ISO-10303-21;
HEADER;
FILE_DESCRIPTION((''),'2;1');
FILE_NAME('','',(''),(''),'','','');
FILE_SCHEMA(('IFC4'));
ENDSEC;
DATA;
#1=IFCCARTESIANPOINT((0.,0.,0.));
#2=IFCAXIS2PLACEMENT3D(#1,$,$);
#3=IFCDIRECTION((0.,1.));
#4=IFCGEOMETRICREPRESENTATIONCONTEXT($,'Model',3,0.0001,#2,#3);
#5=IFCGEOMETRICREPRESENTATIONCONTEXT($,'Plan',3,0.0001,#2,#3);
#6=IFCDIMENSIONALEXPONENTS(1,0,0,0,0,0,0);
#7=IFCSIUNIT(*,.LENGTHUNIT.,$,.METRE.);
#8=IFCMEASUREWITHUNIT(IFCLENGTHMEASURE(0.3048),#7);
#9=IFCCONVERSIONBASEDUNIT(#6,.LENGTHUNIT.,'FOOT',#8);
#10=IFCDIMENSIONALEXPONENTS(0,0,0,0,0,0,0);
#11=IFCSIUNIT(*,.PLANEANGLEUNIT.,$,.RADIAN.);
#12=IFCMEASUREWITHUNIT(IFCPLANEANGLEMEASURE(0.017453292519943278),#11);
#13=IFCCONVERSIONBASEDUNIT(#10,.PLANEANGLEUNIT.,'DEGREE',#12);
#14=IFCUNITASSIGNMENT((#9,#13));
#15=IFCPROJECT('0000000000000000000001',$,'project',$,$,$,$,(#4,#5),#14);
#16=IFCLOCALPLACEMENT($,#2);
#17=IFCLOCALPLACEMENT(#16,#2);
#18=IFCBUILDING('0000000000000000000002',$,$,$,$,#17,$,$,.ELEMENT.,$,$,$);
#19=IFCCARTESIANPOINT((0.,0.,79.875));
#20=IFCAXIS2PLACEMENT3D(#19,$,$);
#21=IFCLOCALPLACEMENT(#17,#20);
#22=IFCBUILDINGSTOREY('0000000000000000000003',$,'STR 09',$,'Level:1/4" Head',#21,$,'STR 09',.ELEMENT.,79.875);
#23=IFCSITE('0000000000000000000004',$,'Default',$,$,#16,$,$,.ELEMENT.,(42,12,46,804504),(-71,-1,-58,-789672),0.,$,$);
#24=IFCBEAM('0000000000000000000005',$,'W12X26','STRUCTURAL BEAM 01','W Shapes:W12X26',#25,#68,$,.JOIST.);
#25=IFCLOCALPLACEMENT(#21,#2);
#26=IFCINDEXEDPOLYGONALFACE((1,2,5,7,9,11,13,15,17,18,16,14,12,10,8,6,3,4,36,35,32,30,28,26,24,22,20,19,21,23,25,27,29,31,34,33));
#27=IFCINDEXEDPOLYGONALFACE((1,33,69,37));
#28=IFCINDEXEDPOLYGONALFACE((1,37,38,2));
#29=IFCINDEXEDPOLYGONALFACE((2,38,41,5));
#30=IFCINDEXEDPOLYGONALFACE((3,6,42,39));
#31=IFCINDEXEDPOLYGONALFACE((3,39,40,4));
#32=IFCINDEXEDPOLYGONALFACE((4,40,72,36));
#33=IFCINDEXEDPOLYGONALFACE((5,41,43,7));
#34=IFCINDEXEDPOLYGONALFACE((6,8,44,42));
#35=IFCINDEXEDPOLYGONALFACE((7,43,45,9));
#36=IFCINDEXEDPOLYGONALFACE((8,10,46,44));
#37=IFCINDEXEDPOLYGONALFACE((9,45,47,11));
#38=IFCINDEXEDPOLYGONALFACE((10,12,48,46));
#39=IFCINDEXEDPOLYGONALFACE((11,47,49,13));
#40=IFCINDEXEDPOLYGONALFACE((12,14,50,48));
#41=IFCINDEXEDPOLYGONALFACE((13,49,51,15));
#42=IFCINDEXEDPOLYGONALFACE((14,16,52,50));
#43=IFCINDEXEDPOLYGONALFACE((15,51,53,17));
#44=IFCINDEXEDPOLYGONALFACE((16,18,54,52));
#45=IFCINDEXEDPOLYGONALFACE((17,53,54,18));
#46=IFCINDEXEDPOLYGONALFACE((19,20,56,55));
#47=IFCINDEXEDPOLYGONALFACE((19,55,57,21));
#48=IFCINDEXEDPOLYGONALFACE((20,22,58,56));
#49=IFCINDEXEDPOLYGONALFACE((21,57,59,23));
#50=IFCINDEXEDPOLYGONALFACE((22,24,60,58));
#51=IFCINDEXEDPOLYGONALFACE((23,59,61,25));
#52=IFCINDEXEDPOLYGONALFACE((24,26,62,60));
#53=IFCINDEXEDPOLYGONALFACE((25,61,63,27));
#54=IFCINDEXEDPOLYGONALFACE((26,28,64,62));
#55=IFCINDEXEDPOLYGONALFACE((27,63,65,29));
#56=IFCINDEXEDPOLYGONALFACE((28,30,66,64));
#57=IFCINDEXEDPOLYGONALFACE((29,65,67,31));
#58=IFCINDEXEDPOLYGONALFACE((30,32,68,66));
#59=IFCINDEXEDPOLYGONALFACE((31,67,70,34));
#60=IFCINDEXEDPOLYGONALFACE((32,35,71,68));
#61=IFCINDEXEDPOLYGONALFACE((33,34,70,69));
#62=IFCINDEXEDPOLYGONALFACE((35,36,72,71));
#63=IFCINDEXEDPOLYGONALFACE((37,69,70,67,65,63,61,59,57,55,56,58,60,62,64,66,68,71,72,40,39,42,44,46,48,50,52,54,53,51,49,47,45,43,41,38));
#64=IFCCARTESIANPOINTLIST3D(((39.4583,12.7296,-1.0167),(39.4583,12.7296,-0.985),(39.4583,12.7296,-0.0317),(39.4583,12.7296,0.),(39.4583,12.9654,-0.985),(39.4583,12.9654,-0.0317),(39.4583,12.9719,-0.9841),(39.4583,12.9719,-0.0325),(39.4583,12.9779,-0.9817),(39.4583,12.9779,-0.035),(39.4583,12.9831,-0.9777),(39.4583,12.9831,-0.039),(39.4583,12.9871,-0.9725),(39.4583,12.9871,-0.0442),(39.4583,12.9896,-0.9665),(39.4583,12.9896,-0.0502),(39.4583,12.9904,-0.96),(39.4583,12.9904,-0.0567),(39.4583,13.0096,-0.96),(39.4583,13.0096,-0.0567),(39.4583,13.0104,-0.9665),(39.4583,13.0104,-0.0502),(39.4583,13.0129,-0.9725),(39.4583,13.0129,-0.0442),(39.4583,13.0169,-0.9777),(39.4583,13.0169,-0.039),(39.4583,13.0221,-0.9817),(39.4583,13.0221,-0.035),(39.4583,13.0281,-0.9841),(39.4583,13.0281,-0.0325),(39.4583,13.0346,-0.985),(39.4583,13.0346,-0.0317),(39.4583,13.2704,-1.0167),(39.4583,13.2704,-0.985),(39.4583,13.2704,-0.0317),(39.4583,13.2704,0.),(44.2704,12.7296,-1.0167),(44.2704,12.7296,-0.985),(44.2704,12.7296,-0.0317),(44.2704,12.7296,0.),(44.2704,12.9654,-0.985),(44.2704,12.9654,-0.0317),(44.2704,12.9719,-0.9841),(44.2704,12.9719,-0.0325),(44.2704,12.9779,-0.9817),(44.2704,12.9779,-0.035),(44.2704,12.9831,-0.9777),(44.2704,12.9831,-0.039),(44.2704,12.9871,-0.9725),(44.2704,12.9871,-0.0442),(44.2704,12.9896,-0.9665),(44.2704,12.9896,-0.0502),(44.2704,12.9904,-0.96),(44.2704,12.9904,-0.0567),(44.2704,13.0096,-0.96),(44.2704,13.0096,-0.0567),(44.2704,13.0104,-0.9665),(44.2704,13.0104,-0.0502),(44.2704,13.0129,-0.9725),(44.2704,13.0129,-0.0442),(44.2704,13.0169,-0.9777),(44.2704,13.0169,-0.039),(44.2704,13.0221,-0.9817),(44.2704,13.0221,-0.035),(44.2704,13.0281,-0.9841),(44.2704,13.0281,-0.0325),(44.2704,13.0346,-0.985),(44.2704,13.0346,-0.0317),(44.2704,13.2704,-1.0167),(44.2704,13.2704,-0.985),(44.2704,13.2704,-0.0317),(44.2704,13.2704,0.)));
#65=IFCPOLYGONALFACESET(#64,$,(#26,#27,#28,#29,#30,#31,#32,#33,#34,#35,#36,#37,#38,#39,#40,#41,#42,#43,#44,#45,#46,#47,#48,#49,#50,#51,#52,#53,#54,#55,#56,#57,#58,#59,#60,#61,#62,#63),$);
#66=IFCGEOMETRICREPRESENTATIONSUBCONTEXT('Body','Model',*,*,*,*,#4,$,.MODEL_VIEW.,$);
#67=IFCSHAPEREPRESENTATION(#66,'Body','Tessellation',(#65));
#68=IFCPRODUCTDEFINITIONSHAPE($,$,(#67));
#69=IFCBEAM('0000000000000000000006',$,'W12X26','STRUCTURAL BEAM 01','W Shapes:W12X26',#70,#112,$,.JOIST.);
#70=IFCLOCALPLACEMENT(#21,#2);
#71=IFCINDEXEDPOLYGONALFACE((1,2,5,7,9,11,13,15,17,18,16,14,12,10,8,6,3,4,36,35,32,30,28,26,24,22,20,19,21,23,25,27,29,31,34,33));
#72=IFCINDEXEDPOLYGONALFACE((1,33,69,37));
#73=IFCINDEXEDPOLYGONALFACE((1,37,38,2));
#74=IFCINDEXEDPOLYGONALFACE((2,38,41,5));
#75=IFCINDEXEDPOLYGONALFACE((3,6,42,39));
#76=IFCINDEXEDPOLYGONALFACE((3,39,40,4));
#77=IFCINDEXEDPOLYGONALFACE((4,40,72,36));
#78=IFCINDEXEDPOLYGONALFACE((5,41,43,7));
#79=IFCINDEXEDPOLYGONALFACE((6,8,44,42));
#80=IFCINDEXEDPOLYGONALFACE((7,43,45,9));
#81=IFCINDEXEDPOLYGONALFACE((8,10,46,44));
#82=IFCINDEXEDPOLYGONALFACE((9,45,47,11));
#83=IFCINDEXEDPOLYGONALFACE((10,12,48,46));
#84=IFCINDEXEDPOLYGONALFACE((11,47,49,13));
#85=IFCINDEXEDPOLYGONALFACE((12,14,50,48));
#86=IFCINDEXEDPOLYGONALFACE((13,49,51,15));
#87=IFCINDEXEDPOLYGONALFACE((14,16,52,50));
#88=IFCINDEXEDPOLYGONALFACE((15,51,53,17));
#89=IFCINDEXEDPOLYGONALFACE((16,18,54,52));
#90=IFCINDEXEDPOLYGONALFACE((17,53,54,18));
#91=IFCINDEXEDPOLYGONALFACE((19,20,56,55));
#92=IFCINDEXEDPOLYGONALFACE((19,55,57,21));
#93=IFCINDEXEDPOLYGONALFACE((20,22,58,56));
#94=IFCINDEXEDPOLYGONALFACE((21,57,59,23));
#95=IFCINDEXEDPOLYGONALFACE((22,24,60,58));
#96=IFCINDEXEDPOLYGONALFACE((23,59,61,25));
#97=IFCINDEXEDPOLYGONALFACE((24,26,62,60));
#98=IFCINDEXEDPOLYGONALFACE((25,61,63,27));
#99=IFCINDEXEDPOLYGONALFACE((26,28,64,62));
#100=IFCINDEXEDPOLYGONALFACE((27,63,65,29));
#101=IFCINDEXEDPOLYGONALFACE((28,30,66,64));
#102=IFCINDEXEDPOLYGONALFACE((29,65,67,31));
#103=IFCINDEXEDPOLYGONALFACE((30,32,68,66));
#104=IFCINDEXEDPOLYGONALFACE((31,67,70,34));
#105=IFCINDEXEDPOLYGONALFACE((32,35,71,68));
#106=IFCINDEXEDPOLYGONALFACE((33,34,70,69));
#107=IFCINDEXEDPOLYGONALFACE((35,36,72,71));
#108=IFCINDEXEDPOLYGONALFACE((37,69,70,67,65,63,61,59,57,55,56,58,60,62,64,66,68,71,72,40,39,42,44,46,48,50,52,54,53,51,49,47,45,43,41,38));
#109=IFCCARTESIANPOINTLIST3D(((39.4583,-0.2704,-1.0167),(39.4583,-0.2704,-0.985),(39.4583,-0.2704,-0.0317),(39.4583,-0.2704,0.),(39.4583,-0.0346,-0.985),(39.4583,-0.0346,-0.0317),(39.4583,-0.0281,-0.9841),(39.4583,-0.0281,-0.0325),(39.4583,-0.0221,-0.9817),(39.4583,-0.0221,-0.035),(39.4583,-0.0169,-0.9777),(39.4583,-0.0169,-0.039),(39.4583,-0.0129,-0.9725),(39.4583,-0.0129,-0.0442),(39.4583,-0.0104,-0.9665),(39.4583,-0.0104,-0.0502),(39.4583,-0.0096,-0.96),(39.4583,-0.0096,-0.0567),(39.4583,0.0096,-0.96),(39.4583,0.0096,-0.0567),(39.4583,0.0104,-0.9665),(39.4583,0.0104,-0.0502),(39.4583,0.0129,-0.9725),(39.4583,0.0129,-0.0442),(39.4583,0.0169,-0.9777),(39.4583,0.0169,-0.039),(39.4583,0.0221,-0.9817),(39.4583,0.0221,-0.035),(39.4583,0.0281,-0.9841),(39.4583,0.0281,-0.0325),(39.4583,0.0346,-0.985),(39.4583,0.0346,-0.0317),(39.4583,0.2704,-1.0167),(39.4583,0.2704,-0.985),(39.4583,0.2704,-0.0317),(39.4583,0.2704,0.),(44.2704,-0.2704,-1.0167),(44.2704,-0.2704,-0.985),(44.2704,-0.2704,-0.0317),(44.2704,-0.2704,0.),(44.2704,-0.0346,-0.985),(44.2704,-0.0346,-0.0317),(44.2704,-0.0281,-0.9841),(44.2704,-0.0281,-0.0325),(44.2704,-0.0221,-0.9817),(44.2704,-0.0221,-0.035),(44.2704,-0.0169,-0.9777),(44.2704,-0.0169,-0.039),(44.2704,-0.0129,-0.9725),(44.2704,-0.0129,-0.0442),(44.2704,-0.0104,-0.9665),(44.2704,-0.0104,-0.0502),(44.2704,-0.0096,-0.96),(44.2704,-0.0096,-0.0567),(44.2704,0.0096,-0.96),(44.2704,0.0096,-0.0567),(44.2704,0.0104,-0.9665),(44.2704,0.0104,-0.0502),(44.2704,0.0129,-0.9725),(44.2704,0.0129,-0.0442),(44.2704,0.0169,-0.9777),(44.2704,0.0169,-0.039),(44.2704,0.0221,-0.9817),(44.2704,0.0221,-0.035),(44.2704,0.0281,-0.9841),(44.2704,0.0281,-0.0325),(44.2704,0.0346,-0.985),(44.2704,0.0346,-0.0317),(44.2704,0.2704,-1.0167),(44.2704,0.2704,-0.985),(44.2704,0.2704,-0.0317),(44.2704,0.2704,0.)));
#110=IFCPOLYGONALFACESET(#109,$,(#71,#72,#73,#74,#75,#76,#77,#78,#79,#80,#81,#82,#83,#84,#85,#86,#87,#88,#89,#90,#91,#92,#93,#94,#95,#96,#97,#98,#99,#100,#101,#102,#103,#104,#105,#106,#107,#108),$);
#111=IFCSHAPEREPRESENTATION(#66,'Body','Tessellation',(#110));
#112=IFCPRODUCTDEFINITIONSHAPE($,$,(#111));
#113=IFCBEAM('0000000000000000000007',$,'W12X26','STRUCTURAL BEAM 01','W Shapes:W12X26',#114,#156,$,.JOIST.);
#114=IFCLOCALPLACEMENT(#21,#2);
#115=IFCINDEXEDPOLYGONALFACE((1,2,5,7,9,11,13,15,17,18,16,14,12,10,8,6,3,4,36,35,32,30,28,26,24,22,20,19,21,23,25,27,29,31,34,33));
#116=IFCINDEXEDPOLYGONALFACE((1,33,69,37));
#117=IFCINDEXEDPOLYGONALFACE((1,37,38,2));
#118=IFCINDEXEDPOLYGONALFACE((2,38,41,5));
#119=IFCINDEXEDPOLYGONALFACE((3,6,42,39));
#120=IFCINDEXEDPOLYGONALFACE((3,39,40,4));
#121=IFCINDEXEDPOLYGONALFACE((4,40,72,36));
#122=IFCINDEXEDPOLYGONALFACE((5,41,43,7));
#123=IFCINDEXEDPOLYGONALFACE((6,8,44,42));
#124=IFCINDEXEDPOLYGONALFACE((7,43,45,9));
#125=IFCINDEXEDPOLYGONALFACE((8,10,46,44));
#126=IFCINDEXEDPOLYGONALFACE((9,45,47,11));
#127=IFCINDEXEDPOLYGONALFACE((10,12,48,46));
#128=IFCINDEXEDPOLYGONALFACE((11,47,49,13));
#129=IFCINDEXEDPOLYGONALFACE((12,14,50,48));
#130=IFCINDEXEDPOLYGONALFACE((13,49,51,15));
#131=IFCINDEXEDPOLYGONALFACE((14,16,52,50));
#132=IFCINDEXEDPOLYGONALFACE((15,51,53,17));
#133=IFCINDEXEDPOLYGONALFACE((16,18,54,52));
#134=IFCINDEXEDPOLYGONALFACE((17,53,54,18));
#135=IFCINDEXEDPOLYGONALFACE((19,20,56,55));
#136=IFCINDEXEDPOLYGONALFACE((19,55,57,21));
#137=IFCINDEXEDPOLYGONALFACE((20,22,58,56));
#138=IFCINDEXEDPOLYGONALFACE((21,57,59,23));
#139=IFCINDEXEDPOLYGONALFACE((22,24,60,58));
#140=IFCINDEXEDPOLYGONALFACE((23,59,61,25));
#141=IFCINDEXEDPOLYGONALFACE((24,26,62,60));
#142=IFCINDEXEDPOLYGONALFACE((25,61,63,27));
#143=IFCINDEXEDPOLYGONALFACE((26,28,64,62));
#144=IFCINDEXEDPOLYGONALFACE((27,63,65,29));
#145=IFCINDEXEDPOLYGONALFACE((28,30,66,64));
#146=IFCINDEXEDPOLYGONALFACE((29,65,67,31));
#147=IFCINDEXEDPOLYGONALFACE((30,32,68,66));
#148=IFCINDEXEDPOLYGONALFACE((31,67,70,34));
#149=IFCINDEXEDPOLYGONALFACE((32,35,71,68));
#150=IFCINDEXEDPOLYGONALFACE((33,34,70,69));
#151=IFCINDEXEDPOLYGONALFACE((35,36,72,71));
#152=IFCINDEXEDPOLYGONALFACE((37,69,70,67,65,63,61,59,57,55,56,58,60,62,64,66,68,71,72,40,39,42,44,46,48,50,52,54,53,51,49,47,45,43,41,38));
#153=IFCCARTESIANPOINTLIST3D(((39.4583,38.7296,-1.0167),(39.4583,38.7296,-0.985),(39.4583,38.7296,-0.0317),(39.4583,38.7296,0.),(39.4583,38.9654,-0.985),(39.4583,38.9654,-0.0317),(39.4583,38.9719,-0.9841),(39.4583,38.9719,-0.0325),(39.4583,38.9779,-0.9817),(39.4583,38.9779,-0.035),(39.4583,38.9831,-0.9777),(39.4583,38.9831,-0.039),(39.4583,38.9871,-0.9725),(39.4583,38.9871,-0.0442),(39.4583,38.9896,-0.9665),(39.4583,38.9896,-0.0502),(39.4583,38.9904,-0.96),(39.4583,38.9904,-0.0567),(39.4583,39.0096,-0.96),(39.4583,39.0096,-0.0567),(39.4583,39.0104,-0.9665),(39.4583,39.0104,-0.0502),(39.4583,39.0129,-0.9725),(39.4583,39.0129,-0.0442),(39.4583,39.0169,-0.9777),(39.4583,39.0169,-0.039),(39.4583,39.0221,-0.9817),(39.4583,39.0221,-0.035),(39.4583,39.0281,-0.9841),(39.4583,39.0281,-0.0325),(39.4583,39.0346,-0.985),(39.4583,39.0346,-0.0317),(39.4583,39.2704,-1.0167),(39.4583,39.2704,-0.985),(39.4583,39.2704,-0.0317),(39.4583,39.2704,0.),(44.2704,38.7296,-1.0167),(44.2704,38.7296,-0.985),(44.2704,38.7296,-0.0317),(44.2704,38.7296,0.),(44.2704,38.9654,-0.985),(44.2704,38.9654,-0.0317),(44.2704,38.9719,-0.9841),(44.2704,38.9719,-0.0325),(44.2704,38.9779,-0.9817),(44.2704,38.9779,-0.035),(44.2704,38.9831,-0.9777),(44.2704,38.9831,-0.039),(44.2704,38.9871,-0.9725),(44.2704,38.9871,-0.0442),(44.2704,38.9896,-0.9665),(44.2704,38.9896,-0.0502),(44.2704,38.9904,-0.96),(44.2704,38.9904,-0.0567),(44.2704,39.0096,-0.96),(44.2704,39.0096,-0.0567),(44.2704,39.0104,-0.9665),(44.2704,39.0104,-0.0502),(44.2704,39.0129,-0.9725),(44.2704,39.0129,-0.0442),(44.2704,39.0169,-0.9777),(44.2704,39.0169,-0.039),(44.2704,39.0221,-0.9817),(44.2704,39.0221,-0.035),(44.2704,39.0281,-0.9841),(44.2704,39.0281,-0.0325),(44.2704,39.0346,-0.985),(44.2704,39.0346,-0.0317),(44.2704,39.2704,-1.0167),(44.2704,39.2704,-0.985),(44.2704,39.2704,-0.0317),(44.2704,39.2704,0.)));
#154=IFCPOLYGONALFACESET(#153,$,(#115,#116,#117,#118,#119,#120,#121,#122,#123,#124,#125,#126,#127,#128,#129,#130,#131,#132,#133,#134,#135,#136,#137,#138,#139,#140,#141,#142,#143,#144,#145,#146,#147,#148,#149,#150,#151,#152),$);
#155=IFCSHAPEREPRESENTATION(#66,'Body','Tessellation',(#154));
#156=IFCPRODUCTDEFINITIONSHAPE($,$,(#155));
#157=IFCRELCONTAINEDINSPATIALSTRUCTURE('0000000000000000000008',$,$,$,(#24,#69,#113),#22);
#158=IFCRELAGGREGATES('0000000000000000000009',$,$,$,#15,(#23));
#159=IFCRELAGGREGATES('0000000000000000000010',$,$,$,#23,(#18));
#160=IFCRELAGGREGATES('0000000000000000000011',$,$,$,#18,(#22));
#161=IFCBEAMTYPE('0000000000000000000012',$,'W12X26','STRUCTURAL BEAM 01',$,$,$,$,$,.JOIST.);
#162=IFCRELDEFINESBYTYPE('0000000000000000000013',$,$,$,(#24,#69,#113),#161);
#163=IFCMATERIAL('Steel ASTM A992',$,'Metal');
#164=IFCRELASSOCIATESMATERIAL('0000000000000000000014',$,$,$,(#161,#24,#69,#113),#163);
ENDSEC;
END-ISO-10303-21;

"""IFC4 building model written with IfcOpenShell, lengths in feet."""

from ifc_helpers import new_model, entity, si_unit, converted_unit, direction, frame, origin, place, context, subcontext, project, spatial, line, arc, indexed_curve, outline, extrude, source, transform, mapped, material, type_object, type_shapes, element, save


model = new_model("IFC4")

# Units and contexts
model_context = context("Model", 3, precision=0.0001, world=origin(), true_north=direction((0.0, 1.0)))
plan_context = context("Plan", 3, precision=0.0001, world=origin(), true_north=direction((0.0, 1.0)))
body_context = subcontext(model_context, "Body", "Model", "MODEL_VIEW")
ifc_project = project(units=[converted_unit("LENGTHUNIT", "FOOT", entity("IfcLengthMeasure", 0.3048), si_unit("LENGTHUNIT", "METRE"), dimensions=[1, 0, 0, 0, 0, 0, 0]), converted_unit("PLANEANGLEUNIT", "DEGREE", entity("IfcPlaneAngleMeasure", 0.017453292519943278), si_unit("PLANEANGLEUNIT", "RADIAN"), dimensions=[0, 0, 0, 0, 0, 0, 0])], contexts=[model_context, plan_context])

# Site, building, storey
site_placement = place(None, origin())
site = spatial("IfcSite", under=ifc_project, at=site_placement, Name="Default", CompositionType="ELEMENT", RefLatitude=(42, 12, 46, 804504), RefLongitude=(-71, -1, -58, -789672), RefElevation=0.0)
building_placement = place(site_placement, origin())
building = spatial("IfcBuilding", under=site, at=building_placement, CompositionType="ELEMENT")
storey_placement = place(building_placement, frame((0.0, 0.0, 79.875)))
storey = spatial("IfcBuildingStorey", under=building, at=storey_placement, Name="STR 09", ObjectType="Level:1/4\" Head", LongName="STR 09", CompositionType="ELEMENT", Elevation=79.875)

# Shared definitions
ifc_material = material(Name="Steel ASTM A992", Category="Metal")

# Beams
beam_type_1 = type_object("IfcBeamType", Name="W12X26", Description="STRUCTURAL BEAM 01", PredefinedType="JOIST", material=ifc_material)
shared_shape_1 = source(origin(), body_context, "Body", "SweptSolid", [
    extrude(outline(indexed_curve([(0.4767, -0.2704), (0.5083, -0.2704), (0.5083, 0.2704), (0.4767, 0.2704), (0.4767, 0.0346), (0.4693, 0.0169), (0.4517, 0.0096), (-0.4517, 0.0096), (-0.4693, 0.0169), (-0.4767, 0.0346), (-0.4767, 0.2704), (-0.5083, 0.2704), (-0.5083, -0.2704), (-0.4767, -0.2704), (-0.4767, -0.0346), (-0.4693, -0.0169), (-0.4517, -0.0096), (0.4517, -0.0096), (0.4693, -0.0169), (0.4767, -0.0346)], segments=[line(1, 2, 3, 4, 5), arc(5, 6, 7), line(7, 8), arc(8, 9, 10), line(10, 11, 12, 13, 14, 15), arc(15, 16, 17), line(17, 18), arc(18, 19, 20), line(20, 1)], self_intersect=False)), frame((-2.7704, 0.0, 0.0), z_axis=(1.0, 0.0, 0.0), x_axis=(0.0, 0.0, -1.0)), (0.0, 0.0, 1.0), 4.8121),
])
type_shapes(beam_type_1, [shared_shape_1])
for number, where, z_axis, x_axis, name in (
    (1, (41.5, 13.0, -0.5083), (0.0, 0.0, 1.0), (-1.0, 0.0, 0.0), "W12X26"),
    (2, (41.5, 0.0, -0.5083), (0.0, 0.0, 1.0), (-1.0, 0.0, 0.0), "W12X26"),
    (3, (41.5, 39.0, -0.5083), (0.0, 0.0, 1.0), (-1.0, 0.0, 0.0), "W12X26"),
):
    element("IfcBeam", number, at=place(storey_placement, frame(where, z_axis=z_axis, x_axis=x_axis)), inside=storey, type_object=beam_type_1, material=ifc_material, Name=name, Description="STRUCTURAL BEAM 01", ObjectType="W Shapes:W12X26", PredefinedType="JOIST", context=body_context, shape_type="MappedRepresentation", body=[
        mapped(shared_shape_1, transform((0.0, 0.0, 0.0), scale=1.0)),
    ])

save(model, "model.ifc")
